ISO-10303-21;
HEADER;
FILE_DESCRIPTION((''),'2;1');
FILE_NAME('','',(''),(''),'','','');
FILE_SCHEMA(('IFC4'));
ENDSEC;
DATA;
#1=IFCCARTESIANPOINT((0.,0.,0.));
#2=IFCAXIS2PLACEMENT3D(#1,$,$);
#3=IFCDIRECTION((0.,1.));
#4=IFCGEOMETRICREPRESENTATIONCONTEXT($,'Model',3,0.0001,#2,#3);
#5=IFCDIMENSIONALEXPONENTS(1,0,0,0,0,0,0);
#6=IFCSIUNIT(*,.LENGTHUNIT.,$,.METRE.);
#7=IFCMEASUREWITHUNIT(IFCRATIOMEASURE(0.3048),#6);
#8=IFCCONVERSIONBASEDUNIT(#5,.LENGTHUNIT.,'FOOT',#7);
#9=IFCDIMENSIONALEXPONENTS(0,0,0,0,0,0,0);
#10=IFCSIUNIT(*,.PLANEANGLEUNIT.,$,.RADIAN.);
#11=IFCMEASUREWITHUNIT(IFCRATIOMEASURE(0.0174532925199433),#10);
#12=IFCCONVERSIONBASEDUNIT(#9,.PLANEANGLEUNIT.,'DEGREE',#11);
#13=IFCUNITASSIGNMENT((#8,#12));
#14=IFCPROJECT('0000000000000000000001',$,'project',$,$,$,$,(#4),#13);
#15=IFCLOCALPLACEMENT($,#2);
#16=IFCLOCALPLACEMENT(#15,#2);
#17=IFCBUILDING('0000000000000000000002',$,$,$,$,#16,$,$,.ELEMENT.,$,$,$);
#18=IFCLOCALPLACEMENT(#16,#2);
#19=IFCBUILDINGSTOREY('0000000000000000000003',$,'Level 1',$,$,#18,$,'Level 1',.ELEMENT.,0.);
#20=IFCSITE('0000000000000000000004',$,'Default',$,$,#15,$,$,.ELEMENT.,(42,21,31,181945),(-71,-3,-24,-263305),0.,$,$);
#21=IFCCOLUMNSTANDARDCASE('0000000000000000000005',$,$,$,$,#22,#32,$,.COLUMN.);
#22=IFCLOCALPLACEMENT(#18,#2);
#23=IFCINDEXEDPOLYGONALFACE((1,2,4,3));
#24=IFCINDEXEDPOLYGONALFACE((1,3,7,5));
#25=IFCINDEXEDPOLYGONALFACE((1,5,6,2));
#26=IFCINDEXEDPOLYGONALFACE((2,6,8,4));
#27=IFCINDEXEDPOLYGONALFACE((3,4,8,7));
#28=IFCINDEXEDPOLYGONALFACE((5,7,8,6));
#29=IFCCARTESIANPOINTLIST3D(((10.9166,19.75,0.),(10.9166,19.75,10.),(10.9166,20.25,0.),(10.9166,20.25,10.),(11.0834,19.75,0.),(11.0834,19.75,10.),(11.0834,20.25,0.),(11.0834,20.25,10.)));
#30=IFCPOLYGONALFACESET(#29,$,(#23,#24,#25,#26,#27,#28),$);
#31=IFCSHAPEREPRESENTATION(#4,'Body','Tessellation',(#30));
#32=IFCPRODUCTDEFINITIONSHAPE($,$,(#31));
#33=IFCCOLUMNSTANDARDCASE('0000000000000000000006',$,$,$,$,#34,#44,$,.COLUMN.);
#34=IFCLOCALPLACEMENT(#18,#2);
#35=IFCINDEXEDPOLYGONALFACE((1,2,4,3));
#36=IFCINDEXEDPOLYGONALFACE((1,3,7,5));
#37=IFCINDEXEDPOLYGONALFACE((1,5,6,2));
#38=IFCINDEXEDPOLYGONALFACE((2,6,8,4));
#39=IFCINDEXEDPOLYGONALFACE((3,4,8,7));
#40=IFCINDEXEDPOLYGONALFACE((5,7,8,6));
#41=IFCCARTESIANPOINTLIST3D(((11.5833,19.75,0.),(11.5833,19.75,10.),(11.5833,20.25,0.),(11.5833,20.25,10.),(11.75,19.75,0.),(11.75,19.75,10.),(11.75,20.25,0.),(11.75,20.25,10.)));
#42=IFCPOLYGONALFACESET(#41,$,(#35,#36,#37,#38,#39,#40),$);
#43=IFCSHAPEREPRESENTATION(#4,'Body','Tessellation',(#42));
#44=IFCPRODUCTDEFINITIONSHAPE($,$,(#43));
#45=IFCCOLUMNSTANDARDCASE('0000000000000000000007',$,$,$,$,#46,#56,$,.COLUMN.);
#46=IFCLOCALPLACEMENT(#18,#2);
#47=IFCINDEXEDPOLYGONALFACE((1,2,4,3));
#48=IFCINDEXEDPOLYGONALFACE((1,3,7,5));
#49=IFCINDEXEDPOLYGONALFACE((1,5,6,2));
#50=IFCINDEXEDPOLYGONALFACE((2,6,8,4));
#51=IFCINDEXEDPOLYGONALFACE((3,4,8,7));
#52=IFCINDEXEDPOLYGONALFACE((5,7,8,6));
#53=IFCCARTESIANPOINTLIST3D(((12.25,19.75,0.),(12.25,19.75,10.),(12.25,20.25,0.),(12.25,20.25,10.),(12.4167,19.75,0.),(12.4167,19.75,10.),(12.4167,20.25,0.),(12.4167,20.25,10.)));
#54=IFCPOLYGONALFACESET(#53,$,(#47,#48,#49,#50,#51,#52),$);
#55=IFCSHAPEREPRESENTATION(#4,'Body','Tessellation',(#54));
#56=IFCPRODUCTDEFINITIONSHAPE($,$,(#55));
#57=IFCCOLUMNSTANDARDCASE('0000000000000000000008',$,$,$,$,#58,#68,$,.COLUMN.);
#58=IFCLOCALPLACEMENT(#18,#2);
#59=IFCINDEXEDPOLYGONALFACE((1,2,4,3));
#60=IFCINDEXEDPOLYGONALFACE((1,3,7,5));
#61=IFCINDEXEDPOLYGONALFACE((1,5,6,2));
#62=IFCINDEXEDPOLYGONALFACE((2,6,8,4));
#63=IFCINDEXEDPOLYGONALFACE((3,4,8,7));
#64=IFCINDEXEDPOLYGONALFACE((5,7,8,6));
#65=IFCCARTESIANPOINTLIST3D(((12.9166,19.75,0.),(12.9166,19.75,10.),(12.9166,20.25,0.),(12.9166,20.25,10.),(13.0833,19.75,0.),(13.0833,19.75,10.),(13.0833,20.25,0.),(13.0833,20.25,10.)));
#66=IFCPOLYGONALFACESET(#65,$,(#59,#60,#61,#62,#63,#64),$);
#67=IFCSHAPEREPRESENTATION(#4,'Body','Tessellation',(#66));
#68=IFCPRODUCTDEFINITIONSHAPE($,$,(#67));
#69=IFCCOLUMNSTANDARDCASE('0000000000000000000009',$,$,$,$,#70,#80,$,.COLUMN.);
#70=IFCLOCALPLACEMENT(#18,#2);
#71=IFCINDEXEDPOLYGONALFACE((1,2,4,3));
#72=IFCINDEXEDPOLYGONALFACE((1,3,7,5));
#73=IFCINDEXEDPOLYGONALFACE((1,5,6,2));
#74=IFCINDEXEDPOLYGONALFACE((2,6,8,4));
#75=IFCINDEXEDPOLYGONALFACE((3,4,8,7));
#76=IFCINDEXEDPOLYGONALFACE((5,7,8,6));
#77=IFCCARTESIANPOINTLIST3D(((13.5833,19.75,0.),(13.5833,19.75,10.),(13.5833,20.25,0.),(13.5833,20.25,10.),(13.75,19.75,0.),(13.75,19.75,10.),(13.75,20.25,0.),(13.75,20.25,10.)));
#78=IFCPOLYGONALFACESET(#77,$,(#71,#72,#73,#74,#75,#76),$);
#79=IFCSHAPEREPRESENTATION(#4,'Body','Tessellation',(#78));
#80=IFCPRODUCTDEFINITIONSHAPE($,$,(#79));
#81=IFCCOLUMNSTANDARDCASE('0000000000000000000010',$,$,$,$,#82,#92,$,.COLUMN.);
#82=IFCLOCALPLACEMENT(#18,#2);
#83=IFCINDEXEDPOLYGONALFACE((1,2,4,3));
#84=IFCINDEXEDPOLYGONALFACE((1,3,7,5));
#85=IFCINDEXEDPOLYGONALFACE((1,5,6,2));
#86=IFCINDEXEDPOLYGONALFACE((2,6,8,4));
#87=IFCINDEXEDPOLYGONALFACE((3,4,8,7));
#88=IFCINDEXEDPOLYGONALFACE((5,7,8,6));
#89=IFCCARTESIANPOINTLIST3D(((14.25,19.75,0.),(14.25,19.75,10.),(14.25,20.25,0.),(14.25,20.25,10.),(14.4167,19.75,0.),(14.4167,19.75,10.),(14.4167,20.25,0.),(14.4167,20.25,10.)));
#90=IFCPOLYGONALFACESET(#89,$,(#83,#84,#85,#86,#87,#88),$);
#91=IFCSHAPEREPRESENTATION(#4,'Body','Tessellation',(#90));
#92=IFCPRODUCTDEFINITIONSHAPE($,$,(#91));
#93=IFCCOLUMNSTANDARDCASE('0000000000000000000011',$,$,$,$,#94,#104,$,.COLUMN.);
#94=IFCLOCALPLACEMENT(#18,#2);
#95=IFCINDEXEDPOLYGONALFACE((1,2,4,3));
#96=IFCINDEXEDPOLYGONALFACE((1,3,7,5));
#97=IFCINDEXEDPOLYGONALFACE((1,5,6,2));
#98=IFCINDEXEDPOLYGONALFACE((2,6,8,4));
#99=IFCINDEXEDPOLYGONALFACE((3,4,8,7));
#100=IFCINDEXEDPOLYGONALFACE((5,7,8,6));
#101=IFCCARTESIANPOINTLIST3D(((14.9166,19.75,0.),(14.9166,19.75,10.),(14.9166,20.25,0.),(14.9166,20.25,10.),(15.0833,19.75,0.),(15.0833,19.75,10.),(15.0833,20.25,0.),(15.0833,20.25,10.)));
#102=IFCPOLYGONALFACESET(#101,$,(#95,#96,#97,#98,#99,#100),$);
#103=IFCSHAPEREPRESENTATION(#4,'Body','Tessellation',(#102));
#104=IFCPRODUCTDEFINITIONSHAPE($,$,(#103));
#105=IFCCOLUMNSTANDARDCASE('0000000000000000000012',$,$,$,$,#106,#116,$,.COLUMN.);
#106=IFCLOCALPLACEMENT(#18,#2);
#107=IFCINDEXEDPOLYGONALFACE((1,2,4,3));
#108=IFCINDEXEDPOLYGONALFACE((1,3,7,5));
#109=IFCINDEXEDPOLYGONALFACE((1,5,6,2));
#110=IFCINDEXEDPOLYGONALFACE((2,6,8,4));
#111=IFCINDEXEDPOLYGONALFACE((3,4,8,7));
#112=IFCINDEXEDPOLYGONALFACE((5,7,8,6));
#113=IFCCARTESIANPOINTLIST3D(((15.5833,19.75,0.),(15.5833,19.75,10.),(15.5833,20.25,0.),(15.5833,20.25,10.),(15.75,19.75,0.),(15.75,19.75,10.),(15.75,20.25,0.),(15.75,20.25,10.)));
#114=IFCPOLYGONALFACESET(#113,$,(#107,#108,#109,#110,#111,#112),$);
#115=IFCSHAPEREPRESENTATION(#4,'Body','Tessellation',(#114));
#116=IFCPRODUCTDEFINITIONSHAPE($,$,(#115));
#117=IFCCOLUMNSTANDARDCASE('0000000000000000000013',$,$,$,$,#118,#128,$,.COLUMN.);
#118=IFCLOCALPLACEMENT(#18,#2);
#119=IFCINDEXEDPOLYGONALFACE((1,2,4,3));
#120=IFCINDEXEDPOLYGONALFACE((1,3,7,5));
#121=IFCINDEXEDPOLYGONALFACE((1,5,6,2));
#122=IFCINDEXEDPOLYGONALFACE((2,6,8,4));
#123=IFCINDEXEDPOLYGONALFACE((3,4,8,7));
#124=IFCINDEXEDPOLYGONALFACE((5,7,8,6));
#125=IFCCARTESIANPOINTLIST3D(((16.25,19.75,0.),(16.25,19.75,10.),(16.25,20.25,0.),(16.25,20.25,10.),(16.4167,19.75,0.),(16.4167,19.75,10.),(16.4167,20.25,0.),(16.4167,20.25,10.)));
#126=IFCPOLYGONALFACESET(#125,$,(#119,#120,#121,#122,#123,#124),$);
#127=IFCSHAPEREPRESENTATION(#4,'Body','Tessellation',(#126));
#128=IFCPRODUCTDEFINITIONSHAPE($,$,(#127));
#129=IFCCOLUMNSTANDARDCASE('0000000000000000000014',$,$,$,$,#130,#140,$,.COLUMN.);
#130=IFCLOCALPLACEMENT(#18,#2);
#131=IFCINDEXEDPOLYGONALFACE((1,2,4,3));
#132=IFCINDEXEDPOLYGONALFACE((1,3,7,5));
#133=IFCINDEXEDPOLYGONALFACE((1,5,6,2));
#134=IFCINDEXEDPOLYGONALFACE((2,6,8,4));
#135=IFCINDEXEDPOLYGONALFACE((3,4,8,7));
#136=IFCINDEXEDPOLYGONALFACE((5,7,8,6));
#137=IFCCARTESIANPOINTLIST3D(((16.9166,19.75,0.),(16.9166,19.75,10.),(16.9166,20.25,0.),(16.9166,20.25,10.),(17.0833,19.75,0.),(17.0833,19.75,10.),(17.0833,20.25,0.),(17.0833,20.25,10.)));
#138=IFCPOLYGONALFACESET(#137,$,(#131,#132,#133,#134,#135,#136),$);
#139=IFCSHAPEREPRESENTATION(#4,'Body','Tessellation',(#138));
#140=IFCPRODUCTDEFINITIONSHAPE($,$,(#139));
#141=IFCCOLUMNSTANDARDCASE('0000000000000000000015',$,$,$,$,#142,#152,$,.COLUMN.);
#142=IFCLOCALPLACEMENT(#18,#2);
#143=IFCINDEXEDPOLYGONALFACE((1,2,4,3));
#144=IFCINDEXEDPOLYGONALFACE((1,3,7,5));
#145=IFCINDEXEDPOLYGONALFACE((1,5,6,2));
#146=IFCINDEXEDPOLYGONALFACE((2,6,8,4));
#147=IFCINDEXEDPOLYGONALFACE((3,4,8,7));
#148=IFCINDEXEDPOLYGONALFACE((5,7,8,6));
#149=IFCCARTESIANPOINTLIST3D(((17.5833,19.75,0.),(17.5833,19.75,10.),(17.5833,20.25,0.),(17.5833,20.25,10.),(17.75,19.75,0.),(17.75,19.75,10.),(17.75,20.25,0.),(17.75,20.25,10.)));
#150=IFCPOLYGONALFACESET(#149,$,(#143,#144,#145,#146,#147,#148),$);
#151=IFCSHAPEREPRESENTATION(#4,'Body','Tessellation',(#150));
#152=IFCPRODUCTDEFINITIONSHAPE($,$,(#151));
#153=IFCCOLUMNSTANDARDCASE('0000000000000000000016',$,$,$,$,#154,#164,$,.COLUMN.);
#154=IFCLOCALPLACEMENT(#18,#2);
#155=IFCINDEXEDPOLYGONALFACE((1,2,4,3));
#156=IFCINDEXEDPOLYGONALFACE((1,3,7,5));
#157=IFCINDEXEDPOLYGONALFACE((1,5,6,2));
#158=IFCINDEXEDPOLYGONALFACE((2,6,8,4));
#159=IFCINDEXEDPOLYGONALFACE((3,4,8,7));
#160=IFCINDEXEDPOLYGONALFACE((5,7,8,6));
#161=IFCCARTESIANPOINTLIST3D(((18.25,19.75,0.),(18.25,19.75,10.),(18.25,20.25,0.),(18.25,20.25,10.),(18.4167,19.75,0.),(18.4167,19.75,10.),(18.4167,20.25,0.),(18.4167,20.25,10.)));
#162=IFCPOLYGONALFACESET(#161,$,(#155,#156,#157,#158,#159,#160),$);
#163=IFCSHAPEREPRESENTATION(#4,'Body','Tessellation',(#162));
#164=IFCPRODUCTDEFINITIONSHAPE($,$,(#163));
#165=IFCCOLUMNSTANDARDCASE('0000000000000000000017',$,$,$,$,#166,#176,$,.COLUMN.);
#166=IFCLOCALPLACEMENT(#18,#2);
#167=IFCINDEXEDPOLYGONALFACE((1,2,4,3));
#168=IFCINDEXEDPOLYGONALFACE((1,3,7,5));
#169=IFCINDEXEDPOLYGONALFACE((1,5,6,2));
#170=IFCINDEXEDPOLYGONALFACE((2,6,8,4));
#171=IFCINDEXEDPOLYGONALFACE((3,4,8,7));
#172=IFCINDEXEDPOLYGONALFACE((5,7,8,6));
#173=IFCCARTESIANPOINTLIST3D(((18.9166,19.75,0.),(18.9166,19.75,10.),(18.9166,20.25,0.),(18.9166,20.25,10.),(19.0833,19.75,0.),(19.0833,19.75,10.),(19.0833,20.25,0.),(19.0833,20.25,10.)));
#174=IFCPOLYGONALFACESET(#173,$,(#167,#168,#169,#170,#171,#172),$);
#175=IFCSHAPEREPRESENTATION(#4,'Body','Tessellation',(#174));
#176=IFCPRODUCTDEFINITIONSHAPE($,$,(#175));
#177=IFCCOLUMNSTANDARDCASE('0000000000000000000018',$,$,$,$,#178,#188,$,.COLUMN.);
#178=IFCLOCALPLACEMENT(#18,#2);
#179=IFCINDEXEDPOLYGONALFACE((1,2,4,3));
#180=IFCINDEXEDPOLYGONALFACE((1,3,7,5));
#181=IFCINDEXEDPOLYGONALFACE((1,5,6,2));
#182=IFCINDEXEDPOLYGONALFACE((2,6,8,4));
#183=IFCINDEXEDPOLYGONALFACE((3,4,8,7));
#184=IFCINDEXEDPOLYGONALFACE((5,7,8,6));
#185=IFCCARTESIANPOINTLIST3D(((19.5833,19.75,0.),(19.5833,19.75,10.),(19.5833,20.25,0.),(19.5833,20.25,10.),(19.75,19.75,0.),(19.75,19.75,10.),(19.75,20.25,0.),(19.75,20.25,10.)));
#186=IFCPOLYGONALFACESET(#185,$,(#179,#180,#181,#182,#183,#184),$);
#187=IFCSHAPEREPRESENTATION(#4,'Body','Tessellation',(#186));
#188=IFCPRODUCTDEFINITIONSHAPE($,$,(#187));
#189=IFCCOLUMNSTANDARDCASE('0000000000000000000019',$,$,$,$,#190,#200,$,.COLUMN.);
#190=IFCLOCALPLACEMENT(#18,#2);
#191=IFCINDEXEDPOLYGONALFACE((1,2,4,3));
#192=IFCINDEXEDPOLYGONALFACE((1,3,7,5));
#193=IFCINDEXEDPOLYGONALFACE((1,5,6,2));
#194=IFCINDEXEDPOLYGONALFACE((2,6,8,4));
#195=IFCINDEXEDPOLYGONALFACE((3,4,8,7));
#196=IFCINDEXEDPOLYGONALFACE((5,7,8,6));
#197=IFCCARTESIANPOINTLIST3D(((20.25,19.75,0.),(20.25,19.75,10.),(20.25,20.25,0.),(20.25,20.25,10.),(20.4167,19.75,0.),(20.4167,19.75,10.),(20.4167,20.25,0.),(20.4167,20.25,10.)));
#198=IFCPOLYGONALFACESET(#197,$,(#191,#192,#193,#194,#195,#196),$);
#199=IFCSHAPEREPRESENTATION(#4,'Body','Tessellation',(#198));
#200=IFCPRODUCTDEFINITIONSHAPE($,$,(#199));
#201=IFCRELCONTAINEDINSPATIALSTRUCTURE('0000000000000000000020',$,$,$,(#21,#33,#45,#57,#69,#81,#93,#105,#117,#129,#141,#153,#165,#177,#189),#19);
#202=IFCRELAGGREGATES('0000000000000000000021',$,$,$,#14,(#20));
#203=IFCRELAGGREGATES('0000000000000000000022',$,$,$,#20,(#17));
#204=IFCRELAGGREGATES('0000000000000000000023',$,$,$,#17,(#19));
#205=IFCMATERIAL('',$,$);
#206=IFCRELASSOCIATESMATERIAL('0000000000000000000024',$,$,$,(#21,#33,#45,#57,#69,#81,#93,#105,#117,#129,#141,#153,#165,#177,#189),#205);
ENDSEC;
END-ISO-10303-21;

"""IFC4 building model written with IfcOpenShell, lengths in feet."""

from ifc_helpers import new_model, entity, si_unit, converted_unit, direction, frame, origin, place, context, project, spatial, rectangle, extrude, material, element, save


model = new_model("IFC4")

# Units and contexts
model_context = context("Model", 3, precision=0.0001, world=origin(), true_north=direction((0.0, 1.0)))
ifc_project = project(units=[converted_unit("LENGTHUNIT", "FOOT", entity("IfcRatioMeasure", 0.3048), si_unit("LENGTHUNIT", "METRE"), dimensions=[1, 0, 0, 0, 0, 0, 0]), converted_unit("PLANEANGLEUNIT", "DEGREE", entity("IfcRatioMeasure", 0.0174532925199433), si_unit("PLANEANGLEUNIT", "RADIAN"), dimensions=[0, 0, 0, 0, 0, 0, 0])], contexts=[model_context])

# Site, building, storey
site_placement = place(None, origin())
site = spatial("IfcSite", under=ifc_project, at=site_placement, Name="Default", CompositionType="ELEMENT", RefLatitude=(42, 21, 31, 181945), RefLongitude=(-71, -3, -24, -263305), RefElevation=0.0)
building_placement = place(site_placement, origin())
building = spatial("IfcBuilding", under=site, at=building_placement, CompositionType="ELEMENT")
storey_placement = place(building_placement, origin())
storey = spatial("IfcBuildingStorey", under=building, at=storey_placement, Name="Level 1", LongName="Level 1", CompositionType="ELEMENT", Elevation=0.0)

# Columns
ifc_material_1 = material(Name="")
placement_1 = place(storey_placement, frame((0.25, 20.0, 0.0)))
for number, where, z_axis, x_axis in (
    (1, (10.75, 0.0, 0.0), (0.0, 0.0, 1.0), (1.0, 0.0, 0.0)),
    (2, (11.4167, 0.0, 0.0), (0.0, 0.0, 1.0), (1.0, 0.0, 0.0)),
    (3, (12.0833, 0.0, 0.0), (0.0, 0.0, 1.0), (1.0, 0.0, 0.0)),
    (4, (12.75, 0.0, 0.0), (0.0, 0.0, 1.0), (1.0, 0.0, 0.0)),
    (5, (13.4167, 0.0, 0.0), (0.0, 0.0, 1.0), (1.0, 0.0, 0.0)),
    (6, (14.0833, 0.0, 0.0), (0.0, 0.0, 1.0), (1.0, 0.0, 0.0)),
    (7, (14.75, 0.0, 0.0), (0.0, 0.0, 1.0), (1.0, 0.0, 0.0)),
    (8, (15.4167, 0.0, 0.0), (0.0, 0.0, 1.0), (1.0, 0.0, 0.0)),
    (9, (16.0833, 0.0, 0.0), (0.0, 0.0, 1.0), (1.0, 0.0, 0.0)),
    (10, (16.75, 0.0, 0.0), (0.0, 0.0, 1.0), (1.0, 0.0, 0.0)),
    (11, (17.4167, 0.0, 0.0), (0.0, 0.0, 1.0), (1.0, 0.0, 0.0)),
    (12, (18.0833, 0.0, 0.0), (0.0, 0.0, 1.0), (1.0, 0.0, 0.0)),
    (13, (18.75, 0.0, 0.0), (0.0, 0.0, 1.0), (1.0, 0.0, 0.0)),
    (14, (19.4167, 0.0, 0.0), (0.0, 0.0, 1.0), (1.0, 0.0, 0.0)),
    (15, (20.0833, 0.0, 0.0), (0.0, 0.0, 1.0), (1.0, 0.0, 0.0)),
):
    element("IfcColumnStandardCase", number, at=place(placement_1, frame(where, z_axis=z_axis, x_axis=x_axis)), inside=storey, material=ifc_material_1, PredefinedType="COLUMN", context=model_context, shape_type="SweptSolid", body=[
        extrude(rectangle(XDim=0.1667, YDim=0.5), origin(), (0.0, 0.0, 1.0), 10.0),
    ])

save(model, "model.ifc")
